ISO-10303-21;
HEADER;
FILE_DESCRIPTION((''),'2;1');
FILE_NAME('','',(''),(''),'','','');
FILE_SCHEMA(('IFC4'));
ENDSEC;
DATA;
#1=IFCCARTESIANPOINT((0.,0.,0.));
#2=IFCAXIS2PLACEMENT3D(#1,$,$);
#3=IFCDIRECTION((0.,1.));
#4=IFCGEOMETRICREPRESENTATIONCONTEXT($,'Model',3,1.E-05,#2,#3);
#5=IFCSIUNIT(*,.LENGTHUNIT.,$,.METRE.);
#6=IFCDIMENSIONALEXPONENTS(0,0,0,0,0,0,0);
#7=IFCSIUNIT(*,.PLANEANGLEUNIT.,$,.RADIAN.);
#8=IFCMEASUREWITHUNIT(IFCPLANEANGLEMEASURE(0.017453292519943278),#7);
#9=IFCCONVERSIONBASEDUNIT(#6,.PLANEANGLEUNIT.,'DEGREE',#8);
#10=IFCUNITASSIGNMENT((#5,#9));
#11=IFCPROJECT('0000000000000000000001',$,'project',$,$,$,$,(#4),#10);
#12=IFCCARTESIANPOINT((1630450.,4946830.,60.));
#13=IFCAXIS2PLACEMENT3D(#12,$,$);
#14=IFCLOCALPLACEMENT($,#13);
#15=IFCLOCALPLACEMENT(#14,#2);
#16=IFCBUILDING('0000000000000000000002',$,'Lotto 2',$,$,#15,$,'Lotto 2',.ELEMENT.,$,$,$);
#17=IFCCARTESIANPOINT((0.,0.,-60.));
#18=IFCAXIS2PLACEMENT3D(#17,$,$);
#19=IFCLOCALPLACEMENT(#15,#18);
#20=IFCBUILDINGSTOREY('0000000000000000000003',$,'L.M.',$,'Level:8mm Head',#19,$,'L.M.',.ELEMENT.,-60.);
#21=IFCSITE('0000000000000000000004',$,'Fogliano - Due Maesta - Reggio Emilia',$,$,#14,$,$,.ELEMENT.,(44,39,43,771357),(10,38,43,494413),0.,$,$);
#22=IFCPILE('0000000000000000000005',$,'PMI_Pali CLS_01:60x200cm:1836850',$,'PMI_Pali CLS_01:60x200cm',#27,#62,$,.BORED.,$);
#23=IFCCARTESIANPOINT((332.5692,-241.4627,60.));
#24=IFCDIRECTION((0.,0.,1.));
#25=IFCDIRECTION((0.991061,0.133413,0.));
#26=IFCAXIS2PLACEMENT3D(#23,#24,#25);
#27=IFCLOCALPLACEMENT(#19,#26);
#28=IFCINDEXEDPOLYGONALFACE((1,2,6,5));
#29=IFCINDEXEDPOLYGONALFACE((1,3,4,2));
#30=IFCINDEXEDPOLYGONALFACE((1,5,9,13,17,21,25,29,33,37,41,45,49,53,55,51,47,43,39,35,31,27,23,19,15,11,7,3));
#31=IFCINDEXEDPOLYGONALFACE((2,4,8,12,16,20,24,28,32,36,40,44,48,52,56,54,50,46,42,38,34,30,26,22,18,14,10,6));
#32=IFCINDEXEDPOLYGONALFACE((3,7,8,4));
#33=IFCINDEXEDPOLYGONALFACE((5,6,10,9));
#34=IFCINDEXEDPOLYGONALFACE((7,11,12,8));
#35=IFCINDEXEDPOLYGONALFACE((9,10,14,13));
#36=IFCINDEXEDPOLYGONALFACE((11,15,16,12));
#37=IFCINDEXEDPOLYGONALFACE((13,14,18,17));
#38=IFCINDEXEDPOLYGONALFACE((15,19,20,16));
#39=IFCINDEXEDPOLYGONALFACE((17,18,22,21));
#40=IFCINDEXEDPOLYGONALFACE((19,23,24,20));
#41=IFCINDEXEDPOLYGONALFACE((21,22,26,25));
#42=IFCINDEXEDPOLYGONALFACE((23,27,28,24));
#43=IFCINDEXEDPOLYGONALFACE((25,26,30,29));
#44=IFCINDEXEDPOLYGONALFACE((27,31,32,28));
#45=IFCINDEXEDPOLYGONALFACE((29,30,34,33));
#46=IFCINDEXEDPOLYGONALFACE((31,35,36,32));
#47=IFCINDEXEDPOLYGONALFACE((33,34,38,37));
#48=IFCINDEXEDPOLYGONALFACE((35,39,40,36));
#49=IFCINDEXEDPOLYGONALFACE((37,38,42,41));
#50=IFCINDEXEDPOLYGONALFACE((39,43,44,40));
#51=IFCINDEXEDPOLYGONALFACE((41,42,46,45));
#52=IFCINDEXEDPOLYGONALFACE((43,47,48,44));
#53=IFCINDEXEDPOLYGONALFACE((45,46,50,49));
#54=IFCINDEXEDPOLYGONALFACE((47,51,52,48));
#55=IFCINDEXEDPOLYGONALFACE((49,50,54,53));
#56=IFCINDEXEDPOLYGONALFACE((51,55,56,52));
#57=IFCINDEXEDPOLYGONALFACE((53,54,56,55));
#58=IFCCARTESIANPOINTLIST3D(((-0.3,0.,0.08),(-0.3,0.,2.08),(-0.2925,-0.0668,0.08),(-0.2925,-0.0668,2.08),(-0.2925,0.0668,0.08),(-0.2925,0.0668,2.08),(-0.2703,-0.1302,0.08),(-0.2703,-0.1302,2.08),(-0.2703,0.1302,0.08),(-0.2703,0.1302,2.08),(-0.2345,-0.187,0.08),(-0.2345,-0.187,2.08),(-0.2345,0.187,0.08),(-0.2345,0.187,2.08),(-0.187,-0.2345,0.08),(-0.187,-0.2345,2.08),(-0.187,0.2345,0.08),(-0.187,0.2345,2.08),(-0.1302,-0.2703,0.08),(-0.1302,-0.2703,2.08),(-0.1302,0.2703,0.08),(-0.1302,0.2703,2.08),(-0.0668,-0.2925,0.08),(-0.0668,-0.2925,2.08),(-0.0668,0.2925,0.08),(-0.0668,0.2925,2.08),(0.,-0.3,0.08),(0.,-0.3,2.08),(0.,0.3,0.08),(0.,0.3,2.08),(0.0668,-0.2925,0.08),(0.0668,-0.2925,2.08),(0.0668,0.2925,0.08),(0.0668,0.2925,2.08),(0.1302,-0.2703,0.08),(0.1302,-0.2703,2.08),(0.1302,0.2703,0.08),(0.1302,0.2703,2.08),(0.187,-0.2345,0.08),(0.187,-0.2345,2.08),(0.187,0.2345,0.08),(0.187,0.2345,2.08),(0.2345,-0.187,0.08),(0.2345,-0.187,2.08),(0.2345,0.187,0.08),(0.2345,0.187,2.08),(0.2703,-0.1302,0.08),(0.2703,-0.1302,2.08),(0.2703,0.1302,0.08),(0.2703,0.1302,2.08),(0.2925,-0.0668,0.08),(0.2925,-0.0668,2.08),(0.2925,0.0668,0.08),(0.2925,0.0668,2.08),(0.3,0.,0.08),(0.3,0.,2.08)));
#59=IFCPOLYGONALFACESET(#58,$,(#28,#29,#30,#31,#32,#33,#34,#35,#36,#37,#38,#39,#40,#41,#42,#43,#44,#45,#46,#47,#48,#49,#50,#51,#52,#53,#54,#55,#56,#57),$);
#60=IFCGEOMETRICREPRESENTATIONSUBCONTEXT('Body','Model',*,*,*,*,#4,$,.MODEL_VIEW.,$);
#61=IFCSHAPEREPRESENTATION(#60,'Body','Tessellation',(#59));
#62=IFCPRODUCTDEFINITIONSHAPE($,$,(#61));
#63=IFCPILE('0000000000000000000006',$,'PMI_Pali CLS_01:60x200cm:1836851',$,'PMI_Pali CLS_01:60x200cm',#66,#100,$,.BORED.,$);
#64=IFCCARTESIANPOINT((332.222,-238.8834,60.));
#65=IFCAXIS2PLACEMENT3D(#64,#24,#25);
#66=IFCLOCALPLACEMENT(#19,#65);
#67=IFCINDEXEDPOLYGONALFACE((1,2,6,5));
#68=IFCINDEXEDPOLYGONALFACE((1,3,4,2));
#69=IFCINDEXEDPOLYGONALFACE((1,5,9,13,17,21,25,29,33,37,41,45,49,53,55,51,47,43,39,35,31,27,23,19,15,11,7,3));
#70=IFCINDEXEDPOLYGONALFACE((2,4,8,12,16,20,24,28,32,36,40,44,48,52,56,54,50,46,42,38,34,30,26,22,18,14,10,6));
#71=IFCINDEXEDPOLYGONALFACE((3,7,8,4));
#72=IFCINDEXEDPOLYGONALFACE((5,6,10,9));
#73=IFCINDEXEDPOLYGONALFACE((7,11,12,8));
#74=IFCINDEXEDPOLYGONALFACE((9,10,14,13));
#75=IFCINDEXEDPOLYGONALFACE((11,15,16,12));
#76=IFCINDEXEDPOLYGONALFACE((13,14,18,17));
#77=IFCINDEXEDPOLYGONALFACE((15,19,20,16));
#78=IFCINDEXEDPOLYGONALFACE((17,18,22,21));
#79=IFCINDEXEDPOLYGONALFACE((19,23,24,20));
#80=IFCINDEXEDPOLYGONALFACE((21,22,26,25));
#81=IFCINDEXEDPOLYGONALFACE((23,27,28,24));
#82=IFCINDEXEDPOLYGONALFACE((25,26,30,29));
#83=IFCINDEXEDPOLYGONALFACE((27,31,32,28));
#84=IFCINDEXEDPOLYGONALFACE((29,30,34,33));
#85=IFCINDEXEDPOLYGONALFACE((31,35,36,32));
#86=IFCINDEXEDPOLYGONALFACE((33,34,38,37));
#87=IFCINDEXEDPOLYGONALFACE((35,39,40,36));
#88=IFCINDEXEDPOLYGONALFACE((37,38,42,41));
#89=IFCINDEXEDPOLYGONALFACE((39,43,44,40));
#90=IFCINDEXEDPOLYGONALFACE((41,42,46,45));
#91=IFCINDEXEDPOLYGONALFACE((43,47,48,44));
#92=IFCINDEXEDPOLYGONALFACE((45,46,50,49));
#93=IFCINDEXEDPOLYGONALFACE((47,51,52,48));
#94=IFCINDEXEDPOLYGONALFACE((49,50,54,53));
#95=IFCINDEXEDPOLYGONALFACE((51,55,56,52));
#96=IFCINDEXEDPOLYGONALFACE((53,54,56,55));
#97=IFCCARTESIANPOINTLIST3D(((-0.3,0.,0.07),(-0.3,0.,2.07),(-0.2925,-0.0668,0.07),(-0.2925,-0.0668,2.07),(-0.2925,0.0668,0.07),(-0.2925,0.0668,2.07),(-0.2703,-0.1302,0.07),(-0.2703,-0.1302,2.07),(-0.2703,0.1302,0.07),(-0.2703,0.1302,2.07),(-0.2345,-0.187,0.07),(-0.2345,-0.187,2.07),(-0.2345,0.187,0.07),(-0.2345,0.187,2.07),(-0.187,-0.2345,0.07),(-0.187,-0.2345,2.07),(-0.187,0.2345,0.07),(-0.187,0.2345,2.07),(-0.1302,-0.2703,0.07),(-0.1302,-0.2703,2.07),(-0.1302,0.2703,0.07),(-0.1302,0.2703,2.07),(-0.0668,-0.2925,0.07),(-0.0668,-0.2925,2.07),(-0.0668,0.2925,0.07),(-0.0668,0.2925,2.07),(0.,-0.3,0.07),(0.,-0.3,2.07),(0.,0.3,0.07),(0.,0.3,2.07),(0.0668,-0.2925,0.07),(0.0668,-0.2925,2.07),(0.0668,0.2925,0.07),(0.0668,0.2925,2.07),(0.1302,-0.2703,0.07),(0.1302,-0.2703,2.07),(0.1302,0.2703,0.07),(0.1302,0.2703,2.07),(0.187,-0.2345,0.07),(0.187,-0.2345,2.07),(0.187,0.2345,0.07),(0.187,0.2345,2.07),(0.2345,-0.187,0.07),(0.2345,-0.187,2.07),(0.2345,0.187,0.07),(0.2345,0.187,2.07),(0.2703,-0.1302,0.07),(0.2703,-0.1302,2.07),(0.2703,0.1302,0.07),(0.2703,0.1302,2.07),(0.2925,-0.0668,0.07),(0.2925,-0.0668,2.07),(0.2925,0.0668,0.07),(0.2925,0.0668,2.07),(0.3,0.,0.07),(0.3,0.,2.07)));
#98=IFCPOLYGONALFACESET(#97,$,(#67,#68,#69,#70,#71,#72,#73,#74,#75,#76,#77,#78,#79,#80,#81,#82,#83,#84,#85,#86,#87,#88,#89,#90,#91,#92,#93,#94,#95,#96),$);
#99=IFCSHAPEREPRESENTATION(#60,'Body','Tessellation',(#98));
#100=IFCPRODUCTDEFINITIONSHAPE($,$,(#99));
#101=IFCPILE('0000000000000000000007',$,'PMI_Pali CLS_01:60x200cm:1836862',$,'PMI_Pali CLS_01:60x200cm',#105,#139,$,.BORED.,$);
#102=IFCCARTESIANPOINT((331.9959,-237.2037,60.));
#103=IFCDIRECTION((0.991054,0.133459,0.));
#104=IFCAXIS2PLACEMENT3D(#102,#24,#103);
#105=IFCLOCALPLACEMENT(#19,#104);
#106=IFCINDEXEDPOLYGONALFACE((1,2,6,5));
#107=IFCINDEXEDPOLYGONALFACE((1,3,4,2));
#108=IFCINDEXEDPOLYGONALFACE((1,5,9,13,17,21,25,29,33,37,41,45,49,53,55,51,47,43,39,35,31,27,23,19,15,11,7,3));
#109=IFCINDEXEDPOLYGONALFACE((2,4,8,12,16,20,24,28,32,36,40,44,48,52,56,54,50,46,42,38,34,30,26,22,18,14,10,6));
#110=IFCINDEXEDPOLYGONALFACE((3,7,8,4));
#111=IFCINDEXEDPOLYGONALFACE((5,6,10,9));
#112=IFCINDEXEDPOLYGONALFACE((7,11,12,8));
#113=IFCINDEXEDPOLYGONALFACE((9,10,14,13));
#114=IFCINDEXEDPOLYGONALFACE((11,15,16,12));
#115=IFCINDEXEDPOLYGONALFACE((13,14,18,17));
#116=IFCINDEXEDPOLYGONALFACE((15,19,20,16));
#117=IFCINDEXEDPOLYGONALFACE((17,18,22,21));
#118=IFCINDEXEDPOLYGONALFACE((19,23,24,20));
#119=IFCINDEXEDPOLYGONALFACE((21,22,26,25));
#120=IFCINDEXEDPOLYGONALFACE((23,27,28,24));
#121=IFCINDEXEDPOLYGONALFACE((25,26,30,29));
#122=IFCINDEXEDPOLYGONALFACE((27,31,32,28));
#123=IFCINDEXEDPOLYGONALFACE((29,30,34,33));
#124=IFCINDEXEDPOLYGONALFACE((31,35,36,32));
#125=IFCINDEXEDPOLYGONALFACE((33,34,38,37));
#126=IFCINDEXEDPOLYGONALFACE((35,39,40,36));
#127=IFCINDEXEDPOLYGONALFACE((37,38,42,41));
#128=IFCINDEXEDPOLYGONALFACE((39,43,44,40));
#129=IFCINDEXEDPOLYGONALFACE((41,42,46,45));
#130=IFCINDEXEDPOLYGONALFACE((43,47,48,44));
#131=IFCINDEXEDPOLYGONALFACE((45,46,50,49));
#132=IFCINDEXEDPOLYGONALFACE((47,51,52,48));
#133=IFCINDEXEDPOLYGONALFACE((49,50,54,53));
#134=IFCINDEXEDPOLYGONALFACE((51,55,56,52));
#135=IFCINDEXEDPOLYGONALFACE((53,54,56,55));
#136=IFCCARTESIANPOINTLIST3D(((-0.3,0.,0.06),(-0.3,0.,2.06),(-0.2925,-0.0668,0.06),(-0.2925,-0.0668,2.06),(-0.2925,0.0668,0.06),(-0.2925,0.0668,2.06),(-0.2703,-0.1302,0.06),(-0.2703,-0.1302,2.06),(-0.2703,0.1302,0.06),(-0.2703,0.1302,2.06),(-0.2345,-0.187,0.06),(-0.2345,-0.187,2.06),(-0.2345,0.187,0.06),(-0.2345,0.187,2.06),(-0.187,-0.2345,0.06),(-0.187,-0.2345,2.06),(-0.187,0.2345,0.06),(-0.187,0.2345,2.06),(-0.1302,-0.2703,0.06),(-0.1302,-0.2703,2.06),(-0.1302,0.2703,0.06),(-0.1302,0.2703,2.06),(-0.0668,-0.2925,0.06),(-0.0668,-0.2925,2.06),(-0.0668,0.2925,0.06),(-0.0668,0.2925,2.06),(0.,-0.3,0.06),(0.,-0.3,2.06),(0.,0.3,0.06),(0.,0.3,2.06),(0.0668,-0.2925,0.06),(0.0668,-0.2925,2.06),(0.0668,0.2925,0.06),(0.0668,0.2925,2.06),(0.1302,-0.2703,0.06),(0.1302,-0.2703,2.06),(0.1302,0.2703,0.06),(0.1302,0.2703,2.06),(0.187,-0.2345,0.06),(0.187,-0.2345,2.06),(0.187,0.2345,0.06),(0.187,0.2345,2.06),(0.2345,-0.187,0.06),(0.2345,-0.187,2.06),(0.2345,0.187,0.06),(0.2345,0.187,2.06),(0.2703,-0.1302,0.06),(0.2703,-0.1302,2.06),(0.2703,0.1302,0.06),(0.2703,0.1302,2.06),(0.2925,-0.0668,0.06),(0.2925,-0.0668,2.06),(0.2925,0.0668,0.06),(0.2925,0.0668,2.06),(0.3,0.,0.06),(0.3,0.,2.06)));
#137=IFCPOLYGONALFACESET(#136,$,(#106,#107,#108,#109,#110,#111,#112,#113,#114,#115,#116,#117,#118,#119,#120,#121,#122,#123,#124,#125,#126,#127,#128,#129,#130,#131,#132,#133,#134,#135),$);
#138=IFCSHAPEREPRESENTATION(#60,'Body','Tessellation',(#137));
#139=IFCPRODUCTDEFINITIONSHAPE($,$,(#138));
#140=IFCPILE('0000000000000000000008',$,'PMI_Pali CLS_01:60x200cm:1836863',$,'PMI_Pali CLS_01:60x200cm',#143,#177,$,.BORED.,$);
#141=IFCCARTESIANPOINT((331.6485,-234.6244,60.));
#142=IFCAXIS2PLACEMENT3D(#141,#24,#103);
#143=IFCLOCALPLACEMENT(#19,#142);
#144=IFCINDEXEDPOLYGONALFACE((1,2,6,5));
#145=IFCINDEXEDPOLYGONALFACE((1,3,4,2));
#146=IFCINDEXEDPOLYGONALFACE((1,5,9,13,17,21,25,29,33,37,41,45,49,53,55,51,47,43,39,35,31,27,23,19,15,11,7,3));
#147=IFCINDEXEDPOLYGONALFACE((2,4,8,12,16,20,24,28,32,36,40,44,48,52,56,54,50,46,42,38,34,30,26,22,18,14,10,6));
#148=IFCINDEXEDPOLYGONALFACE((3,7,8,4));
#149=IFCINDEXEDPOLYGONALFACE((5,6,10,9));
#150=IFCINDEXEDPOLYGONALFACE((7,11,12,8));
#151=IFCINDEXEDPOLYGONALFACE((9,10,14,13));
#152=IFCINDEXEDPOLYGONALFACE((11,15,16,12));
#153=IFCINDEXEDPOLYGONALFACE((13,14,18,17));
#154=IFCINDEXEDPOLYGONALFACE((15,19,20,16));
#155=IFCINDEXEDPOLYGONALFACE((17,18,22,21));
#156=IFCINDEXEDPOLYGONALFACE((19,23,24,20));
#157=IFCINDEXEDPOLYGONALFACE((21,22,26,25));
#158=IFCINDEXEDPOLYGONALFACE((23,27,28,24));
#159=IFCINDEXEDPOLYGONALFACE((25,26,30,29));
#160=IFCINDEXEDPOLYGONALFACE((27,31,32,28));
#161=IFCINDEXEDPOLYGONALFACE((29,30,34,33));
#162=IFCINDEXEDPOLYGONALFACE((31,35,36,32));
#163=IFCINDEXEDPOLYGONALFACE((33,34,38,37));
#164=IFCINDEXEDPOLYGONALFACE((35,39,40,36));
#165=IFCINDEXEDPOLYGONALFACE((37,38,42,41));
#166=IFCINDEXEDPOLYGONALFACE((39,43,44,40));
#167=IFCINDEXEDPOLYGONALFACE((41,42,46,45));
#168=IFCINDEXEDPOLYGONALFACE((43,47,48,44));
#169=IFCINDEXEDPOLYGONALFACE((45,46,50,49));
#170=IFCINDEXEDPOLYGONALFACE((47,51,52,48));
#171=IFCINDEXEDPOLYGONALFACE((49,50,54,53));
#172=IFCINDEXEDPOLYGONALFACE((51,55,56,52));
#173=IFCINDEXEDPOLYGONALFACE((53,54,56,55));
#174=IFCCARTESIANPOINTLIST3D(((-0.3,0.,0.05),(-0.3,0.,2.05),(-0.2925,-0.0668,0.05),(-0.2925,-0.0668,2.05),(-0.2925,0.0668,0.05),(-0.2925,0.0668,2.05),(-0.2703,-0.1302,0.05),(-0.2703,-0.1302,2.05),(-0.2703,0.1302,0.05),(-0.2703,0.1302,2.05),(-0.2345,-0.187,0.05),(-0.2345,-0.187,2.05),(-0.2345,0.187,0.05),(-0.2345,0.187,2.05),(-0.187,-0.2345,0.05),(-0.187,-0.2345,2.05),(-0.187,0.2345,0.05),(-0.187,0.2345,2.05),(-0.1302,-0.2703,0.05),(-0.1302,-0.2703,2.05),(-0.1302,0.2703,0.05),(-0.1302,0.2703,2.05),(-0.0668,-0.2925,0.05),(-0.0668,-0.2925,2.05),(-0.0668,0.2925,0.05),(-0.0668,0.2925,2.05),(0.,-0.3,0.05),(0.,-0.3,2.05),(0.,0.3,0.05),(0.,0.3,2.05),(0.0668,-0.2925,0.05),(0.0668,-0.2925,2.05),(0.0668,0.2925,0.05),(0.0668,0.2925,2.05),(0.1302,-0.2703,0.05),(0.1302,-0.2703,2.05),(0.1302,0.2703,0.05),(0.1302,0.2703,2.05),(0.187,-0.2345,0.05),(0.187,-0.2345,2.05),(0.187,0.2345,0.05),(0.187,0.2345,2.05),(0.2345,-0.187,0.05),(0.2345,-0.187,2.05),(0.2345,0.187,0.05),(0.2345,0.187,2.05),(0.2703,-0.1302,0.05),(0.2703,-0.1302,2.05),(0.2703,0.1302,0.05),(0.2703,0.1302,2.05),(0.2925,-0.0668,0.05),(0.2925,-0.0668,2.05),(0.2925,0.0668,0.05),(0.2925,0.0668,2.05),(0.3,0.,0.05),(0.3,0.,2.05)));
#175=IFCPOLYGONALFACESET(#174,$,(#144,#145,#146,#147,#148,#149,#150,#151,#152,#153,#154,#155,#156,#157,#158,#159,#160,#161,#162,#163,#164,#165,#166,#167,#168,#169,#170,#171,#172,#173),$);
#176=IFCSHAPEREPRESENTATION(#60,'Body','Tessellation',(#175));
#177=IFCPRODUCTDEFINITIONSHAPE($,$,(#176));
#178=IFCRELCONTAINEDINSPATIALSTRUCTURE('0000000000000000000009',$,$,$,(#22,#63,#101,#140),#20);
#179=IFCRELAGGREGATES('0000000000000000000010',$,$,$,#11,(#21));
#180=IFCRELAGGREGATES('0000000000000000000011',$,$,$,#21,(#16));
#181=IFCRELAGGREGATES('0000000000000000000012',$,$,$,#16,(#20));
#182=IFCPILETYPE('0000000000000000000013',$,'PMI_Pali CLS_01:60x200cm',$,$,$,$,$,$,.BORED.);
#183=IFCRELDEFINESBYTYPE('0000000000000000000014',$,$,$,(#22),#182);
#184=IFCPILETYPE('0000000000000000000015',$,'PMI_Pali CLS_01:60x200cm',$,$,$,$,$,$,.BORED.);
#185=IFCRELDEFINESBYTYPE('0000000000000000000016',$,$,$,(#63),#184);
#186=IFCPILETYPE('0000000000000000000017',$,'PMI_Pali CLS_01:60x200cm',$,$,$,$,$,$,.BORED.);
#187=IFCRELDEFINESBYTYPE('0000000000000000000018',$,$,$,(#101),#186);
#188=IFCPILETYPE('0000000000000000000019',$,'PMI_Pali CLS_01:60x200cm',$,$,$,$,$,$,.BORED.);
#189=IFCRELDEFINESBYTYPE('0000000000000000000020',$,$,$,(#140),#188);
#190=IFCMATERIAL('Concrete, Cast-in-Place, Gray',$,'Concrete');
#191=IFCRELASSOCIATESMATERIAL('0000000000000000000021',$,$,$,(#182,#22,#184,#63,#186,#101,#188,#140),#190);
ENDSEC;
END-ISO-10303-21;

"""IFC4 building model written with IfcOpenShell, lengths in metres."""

from ifc_helpers import new_model, entity, si_unit, converted_unit, direction, frame, origin, place, context, subcontext, project, spatial, arc, indexed_curve, outline, extrude, source, transform, mapped, material, type_object, type_shapes, element, save


model = new_model("IFC4")

# Units and contexts
model_context = context("Model", 3, precision=1e-05, world=origin(), true_north=direction((0.0, 1.0)))
body_context = subcontext(model_context, "Body", "Model", "MODEL_VIEW")
ifc_project = project(units=[si_unit("LENGTHUNIT", "METRE"), converted_unit("PLANEANGLEUNIT", "DEGREE", entity("IfcPlaneAngleMeasure", 0.017453292519943278), si_unit("PLANEANGLEUNIT", "RADIAN"), dimensions=[0, 0, 0, 0, 0, 0, 0])], contexts=[model_context])

# Site, building, storey
site_placement = place(None, frame((1630450.0, 4946830.0, 60.0)))
site = spatial("IfcSite", under=ifc_project, at=site_placement, Name="Fogliano - Due Maesta - Reggio Emilia", CompositionType="ELEMENT", RefLatitude=(44, 39, 43, 771357), RefLongitude=(10, 38, 43, 494413), RefElevation=0.0)
building_placement = place(site_placement, origin())
building = spatial("IfcBuilding", under=site, at=building_placement, Name="Lotto 2", LongName="Lotto 2", CompositionType="ELEMENT")
storey_placement = place(building_placement, frame((0.0, 0.0, -60.0)))
storey = spatial("IfcBuildingStorey", under=building, at=storey_placement, Name="L.M.", ObjectType="Level:8mm Head", LongName="L.M.", CompositionType="ELEMENT", Elevation=-60.0)

# Piles
ifc_material_1 = material(Name="Concrete, Cast-in-Place, Gray", Category="Concrete")
pile_type_1 = type_object("IfcPileType", Name="PMI_Pali CLS_01:60x200cm", PredefinedType="BORED", material=ifc_material_1)
shared_shape_1 = source(origin(), body_context, "Body", "SweptSolid", [
    extrude(outline(indexed_curve([(-0.3, 0.0), (0.0, -0.3), (0.3, 0.0), (0.0, 0.3)], segments=[arc(1, 2, 3), arc(3, 4, 1)], self_intersect=False)), frame((0.0, 0.0, 0.08)), (0.0, 0.0, 1.0), 2.0),
])
type_shapes(pile_type_1, [shared_shape_1])
pile_1_placement = place(storey_placement, frame((332.5692, -241.4627, 60.0), z_axis=(0.0, 0.0, 1.0), x_axis=(0.991061, 0.133413, 0.0)))
element("IfcPile", 1, at=pile_1_placement, inside=storey, type_object=pile_type_1, material=ifc_material_1, Name="PMI_Pali CLS_01:60x200cm:1836850", ObjectType="PMI_Pali CLS_01:60x200cm", PredefinedType="BORED", context=body_context, shape_type="MappedRepresentation", body=[
    mapped(shared_shape_1, transform((0.0, 0.0, 0.0), scale=1.0)),
])
pile_type_2 = type_object("IfcPileType", Name="PMI_Pali CLS_01:60x200cm", PredefinedType="BORED", material=ifc_material_1)
shared_shape_2 = source(origin(), body_context, "Body", "SweptSolid", [
    extrude(outline(indexed_curve([(-0.3, 0.0), (0.0, -0.3), (0.3, 0.0), (0.0, 0.3)], segments=[arc(1, 2, 3), arc(3, 4, 1)], self_intersect=False)), frame((0.0, 0.0, 0.07)), (0.0, 0.0, 1.0), 2.0),
])
type_shapes(pile_type_2, [shared_shape_2])
pile_2_placement = place(storey_placement, frame((332.222, -238.8834, 60.0), z_axis=(0.0, 0.0, 1.0), x_axis=(0.991061, 0.133413, 0.0)))
element("IfcPile", 2, at=pile_2_placement, inside=storey, type_object=pile_type_2, material=ifc_material_1, Name="PMI_Pali CLS_01:60x200cm:1836851", ObjectType="PMI_Pali CLS_01:60x200cm", PredefinedType="BORED", context=body_context, shape_type="MappedRepresentation", body=[
    mapped(shared_shape_2, transform((0.0, 0.0, 0.0), scale=1.0)),
])
pile_type_3 = type_object("IfcPileType", Name="PMI_Pali CLS_01:60x200cm", PredefinedType="BORED", material=ifc_material_1)
shared_shape_3 = source(origin(), body_context, "Body", "SweptSolid", [
    extrude(outline(indexed_curve([(-0.3, 0.0), (0.0, -0.3), (0.3, 0.0), (0.0, 0.3)], segments=[arc(1, 2, 3), arc(3, 4, 1)], self_intersect=False)), frame((0.0, 0.0, 0.06)), (0.0, 0.0, 1.0), 2.0),
])
type_shapes(pile_type_3, [shared_shape_3])
pile_3_placement = place(storey_placement, frame((331.9959, -237.2037, 60.0), z_axis=(0.0, 0.0, 1.0), x_axis=(0.991054, 0.133459, 0.0)))
element("IfcPile", 3, at=pile_3_placement, inside=storey, type_object=pile_type_3, material=ifc_material_1, Name="PMI_Pali CLS_01:60x200cm:1836862", ObjectType="PMI_Pali CLS_01:60x200cm", PredefinedType="BORED", context=body_context, shape_type="MappedRepresentation", body=[
    mapped(shared_shape_3, transform((0.0, 0.0, 0.0), scale=1.0)),
])
pile_type_4 = type_object("IfcPileType", Name="PMI_Pali CLS_01:60x200cm", PredefinedType="BORED", material=ifc_material_1)
shared_shape_4 = source(origin(), body_context, "Body", "SweptSolid", [
    extrude(outline(indexed_curve([(-0.3, 0.0), (0.0, -0.3), (0.3, 0.0), (0.0, 0.3)], segments=[arc(1, 2, 3), arc(3, 4, 1)], self_intersect=False)), frame((0.0, 0.0, 0.05)), (0.0, 0.0, 1.0), 2.0),
])
type_shapes(pile_type_4, [shared_shape_4])
pile_4_placement = place(storey_placement, frame((331.6485, -234.6244, 60.0), z_axis=(0.0, 0.0, 1.0), x_axis=(0.991054, 0.133459, 0.0)))
element("IfcPile", 4, at=pile_4_placement, inside=storey, type_object=pile_type_4, material=ifc_material_1, Name="PMI_Pali CLS_01:60x200cm:1836863", ObjectType="PMI_Pali CLS_01:60x200cm", PredefinedType="BORED", context=body_context, shape_type="MappedRepresentation", body=[
    mapped(shared_shape_4, transform((0.0, 0.0, 0.0), scale=1.0)),
])

save(model, "model.ifc")
